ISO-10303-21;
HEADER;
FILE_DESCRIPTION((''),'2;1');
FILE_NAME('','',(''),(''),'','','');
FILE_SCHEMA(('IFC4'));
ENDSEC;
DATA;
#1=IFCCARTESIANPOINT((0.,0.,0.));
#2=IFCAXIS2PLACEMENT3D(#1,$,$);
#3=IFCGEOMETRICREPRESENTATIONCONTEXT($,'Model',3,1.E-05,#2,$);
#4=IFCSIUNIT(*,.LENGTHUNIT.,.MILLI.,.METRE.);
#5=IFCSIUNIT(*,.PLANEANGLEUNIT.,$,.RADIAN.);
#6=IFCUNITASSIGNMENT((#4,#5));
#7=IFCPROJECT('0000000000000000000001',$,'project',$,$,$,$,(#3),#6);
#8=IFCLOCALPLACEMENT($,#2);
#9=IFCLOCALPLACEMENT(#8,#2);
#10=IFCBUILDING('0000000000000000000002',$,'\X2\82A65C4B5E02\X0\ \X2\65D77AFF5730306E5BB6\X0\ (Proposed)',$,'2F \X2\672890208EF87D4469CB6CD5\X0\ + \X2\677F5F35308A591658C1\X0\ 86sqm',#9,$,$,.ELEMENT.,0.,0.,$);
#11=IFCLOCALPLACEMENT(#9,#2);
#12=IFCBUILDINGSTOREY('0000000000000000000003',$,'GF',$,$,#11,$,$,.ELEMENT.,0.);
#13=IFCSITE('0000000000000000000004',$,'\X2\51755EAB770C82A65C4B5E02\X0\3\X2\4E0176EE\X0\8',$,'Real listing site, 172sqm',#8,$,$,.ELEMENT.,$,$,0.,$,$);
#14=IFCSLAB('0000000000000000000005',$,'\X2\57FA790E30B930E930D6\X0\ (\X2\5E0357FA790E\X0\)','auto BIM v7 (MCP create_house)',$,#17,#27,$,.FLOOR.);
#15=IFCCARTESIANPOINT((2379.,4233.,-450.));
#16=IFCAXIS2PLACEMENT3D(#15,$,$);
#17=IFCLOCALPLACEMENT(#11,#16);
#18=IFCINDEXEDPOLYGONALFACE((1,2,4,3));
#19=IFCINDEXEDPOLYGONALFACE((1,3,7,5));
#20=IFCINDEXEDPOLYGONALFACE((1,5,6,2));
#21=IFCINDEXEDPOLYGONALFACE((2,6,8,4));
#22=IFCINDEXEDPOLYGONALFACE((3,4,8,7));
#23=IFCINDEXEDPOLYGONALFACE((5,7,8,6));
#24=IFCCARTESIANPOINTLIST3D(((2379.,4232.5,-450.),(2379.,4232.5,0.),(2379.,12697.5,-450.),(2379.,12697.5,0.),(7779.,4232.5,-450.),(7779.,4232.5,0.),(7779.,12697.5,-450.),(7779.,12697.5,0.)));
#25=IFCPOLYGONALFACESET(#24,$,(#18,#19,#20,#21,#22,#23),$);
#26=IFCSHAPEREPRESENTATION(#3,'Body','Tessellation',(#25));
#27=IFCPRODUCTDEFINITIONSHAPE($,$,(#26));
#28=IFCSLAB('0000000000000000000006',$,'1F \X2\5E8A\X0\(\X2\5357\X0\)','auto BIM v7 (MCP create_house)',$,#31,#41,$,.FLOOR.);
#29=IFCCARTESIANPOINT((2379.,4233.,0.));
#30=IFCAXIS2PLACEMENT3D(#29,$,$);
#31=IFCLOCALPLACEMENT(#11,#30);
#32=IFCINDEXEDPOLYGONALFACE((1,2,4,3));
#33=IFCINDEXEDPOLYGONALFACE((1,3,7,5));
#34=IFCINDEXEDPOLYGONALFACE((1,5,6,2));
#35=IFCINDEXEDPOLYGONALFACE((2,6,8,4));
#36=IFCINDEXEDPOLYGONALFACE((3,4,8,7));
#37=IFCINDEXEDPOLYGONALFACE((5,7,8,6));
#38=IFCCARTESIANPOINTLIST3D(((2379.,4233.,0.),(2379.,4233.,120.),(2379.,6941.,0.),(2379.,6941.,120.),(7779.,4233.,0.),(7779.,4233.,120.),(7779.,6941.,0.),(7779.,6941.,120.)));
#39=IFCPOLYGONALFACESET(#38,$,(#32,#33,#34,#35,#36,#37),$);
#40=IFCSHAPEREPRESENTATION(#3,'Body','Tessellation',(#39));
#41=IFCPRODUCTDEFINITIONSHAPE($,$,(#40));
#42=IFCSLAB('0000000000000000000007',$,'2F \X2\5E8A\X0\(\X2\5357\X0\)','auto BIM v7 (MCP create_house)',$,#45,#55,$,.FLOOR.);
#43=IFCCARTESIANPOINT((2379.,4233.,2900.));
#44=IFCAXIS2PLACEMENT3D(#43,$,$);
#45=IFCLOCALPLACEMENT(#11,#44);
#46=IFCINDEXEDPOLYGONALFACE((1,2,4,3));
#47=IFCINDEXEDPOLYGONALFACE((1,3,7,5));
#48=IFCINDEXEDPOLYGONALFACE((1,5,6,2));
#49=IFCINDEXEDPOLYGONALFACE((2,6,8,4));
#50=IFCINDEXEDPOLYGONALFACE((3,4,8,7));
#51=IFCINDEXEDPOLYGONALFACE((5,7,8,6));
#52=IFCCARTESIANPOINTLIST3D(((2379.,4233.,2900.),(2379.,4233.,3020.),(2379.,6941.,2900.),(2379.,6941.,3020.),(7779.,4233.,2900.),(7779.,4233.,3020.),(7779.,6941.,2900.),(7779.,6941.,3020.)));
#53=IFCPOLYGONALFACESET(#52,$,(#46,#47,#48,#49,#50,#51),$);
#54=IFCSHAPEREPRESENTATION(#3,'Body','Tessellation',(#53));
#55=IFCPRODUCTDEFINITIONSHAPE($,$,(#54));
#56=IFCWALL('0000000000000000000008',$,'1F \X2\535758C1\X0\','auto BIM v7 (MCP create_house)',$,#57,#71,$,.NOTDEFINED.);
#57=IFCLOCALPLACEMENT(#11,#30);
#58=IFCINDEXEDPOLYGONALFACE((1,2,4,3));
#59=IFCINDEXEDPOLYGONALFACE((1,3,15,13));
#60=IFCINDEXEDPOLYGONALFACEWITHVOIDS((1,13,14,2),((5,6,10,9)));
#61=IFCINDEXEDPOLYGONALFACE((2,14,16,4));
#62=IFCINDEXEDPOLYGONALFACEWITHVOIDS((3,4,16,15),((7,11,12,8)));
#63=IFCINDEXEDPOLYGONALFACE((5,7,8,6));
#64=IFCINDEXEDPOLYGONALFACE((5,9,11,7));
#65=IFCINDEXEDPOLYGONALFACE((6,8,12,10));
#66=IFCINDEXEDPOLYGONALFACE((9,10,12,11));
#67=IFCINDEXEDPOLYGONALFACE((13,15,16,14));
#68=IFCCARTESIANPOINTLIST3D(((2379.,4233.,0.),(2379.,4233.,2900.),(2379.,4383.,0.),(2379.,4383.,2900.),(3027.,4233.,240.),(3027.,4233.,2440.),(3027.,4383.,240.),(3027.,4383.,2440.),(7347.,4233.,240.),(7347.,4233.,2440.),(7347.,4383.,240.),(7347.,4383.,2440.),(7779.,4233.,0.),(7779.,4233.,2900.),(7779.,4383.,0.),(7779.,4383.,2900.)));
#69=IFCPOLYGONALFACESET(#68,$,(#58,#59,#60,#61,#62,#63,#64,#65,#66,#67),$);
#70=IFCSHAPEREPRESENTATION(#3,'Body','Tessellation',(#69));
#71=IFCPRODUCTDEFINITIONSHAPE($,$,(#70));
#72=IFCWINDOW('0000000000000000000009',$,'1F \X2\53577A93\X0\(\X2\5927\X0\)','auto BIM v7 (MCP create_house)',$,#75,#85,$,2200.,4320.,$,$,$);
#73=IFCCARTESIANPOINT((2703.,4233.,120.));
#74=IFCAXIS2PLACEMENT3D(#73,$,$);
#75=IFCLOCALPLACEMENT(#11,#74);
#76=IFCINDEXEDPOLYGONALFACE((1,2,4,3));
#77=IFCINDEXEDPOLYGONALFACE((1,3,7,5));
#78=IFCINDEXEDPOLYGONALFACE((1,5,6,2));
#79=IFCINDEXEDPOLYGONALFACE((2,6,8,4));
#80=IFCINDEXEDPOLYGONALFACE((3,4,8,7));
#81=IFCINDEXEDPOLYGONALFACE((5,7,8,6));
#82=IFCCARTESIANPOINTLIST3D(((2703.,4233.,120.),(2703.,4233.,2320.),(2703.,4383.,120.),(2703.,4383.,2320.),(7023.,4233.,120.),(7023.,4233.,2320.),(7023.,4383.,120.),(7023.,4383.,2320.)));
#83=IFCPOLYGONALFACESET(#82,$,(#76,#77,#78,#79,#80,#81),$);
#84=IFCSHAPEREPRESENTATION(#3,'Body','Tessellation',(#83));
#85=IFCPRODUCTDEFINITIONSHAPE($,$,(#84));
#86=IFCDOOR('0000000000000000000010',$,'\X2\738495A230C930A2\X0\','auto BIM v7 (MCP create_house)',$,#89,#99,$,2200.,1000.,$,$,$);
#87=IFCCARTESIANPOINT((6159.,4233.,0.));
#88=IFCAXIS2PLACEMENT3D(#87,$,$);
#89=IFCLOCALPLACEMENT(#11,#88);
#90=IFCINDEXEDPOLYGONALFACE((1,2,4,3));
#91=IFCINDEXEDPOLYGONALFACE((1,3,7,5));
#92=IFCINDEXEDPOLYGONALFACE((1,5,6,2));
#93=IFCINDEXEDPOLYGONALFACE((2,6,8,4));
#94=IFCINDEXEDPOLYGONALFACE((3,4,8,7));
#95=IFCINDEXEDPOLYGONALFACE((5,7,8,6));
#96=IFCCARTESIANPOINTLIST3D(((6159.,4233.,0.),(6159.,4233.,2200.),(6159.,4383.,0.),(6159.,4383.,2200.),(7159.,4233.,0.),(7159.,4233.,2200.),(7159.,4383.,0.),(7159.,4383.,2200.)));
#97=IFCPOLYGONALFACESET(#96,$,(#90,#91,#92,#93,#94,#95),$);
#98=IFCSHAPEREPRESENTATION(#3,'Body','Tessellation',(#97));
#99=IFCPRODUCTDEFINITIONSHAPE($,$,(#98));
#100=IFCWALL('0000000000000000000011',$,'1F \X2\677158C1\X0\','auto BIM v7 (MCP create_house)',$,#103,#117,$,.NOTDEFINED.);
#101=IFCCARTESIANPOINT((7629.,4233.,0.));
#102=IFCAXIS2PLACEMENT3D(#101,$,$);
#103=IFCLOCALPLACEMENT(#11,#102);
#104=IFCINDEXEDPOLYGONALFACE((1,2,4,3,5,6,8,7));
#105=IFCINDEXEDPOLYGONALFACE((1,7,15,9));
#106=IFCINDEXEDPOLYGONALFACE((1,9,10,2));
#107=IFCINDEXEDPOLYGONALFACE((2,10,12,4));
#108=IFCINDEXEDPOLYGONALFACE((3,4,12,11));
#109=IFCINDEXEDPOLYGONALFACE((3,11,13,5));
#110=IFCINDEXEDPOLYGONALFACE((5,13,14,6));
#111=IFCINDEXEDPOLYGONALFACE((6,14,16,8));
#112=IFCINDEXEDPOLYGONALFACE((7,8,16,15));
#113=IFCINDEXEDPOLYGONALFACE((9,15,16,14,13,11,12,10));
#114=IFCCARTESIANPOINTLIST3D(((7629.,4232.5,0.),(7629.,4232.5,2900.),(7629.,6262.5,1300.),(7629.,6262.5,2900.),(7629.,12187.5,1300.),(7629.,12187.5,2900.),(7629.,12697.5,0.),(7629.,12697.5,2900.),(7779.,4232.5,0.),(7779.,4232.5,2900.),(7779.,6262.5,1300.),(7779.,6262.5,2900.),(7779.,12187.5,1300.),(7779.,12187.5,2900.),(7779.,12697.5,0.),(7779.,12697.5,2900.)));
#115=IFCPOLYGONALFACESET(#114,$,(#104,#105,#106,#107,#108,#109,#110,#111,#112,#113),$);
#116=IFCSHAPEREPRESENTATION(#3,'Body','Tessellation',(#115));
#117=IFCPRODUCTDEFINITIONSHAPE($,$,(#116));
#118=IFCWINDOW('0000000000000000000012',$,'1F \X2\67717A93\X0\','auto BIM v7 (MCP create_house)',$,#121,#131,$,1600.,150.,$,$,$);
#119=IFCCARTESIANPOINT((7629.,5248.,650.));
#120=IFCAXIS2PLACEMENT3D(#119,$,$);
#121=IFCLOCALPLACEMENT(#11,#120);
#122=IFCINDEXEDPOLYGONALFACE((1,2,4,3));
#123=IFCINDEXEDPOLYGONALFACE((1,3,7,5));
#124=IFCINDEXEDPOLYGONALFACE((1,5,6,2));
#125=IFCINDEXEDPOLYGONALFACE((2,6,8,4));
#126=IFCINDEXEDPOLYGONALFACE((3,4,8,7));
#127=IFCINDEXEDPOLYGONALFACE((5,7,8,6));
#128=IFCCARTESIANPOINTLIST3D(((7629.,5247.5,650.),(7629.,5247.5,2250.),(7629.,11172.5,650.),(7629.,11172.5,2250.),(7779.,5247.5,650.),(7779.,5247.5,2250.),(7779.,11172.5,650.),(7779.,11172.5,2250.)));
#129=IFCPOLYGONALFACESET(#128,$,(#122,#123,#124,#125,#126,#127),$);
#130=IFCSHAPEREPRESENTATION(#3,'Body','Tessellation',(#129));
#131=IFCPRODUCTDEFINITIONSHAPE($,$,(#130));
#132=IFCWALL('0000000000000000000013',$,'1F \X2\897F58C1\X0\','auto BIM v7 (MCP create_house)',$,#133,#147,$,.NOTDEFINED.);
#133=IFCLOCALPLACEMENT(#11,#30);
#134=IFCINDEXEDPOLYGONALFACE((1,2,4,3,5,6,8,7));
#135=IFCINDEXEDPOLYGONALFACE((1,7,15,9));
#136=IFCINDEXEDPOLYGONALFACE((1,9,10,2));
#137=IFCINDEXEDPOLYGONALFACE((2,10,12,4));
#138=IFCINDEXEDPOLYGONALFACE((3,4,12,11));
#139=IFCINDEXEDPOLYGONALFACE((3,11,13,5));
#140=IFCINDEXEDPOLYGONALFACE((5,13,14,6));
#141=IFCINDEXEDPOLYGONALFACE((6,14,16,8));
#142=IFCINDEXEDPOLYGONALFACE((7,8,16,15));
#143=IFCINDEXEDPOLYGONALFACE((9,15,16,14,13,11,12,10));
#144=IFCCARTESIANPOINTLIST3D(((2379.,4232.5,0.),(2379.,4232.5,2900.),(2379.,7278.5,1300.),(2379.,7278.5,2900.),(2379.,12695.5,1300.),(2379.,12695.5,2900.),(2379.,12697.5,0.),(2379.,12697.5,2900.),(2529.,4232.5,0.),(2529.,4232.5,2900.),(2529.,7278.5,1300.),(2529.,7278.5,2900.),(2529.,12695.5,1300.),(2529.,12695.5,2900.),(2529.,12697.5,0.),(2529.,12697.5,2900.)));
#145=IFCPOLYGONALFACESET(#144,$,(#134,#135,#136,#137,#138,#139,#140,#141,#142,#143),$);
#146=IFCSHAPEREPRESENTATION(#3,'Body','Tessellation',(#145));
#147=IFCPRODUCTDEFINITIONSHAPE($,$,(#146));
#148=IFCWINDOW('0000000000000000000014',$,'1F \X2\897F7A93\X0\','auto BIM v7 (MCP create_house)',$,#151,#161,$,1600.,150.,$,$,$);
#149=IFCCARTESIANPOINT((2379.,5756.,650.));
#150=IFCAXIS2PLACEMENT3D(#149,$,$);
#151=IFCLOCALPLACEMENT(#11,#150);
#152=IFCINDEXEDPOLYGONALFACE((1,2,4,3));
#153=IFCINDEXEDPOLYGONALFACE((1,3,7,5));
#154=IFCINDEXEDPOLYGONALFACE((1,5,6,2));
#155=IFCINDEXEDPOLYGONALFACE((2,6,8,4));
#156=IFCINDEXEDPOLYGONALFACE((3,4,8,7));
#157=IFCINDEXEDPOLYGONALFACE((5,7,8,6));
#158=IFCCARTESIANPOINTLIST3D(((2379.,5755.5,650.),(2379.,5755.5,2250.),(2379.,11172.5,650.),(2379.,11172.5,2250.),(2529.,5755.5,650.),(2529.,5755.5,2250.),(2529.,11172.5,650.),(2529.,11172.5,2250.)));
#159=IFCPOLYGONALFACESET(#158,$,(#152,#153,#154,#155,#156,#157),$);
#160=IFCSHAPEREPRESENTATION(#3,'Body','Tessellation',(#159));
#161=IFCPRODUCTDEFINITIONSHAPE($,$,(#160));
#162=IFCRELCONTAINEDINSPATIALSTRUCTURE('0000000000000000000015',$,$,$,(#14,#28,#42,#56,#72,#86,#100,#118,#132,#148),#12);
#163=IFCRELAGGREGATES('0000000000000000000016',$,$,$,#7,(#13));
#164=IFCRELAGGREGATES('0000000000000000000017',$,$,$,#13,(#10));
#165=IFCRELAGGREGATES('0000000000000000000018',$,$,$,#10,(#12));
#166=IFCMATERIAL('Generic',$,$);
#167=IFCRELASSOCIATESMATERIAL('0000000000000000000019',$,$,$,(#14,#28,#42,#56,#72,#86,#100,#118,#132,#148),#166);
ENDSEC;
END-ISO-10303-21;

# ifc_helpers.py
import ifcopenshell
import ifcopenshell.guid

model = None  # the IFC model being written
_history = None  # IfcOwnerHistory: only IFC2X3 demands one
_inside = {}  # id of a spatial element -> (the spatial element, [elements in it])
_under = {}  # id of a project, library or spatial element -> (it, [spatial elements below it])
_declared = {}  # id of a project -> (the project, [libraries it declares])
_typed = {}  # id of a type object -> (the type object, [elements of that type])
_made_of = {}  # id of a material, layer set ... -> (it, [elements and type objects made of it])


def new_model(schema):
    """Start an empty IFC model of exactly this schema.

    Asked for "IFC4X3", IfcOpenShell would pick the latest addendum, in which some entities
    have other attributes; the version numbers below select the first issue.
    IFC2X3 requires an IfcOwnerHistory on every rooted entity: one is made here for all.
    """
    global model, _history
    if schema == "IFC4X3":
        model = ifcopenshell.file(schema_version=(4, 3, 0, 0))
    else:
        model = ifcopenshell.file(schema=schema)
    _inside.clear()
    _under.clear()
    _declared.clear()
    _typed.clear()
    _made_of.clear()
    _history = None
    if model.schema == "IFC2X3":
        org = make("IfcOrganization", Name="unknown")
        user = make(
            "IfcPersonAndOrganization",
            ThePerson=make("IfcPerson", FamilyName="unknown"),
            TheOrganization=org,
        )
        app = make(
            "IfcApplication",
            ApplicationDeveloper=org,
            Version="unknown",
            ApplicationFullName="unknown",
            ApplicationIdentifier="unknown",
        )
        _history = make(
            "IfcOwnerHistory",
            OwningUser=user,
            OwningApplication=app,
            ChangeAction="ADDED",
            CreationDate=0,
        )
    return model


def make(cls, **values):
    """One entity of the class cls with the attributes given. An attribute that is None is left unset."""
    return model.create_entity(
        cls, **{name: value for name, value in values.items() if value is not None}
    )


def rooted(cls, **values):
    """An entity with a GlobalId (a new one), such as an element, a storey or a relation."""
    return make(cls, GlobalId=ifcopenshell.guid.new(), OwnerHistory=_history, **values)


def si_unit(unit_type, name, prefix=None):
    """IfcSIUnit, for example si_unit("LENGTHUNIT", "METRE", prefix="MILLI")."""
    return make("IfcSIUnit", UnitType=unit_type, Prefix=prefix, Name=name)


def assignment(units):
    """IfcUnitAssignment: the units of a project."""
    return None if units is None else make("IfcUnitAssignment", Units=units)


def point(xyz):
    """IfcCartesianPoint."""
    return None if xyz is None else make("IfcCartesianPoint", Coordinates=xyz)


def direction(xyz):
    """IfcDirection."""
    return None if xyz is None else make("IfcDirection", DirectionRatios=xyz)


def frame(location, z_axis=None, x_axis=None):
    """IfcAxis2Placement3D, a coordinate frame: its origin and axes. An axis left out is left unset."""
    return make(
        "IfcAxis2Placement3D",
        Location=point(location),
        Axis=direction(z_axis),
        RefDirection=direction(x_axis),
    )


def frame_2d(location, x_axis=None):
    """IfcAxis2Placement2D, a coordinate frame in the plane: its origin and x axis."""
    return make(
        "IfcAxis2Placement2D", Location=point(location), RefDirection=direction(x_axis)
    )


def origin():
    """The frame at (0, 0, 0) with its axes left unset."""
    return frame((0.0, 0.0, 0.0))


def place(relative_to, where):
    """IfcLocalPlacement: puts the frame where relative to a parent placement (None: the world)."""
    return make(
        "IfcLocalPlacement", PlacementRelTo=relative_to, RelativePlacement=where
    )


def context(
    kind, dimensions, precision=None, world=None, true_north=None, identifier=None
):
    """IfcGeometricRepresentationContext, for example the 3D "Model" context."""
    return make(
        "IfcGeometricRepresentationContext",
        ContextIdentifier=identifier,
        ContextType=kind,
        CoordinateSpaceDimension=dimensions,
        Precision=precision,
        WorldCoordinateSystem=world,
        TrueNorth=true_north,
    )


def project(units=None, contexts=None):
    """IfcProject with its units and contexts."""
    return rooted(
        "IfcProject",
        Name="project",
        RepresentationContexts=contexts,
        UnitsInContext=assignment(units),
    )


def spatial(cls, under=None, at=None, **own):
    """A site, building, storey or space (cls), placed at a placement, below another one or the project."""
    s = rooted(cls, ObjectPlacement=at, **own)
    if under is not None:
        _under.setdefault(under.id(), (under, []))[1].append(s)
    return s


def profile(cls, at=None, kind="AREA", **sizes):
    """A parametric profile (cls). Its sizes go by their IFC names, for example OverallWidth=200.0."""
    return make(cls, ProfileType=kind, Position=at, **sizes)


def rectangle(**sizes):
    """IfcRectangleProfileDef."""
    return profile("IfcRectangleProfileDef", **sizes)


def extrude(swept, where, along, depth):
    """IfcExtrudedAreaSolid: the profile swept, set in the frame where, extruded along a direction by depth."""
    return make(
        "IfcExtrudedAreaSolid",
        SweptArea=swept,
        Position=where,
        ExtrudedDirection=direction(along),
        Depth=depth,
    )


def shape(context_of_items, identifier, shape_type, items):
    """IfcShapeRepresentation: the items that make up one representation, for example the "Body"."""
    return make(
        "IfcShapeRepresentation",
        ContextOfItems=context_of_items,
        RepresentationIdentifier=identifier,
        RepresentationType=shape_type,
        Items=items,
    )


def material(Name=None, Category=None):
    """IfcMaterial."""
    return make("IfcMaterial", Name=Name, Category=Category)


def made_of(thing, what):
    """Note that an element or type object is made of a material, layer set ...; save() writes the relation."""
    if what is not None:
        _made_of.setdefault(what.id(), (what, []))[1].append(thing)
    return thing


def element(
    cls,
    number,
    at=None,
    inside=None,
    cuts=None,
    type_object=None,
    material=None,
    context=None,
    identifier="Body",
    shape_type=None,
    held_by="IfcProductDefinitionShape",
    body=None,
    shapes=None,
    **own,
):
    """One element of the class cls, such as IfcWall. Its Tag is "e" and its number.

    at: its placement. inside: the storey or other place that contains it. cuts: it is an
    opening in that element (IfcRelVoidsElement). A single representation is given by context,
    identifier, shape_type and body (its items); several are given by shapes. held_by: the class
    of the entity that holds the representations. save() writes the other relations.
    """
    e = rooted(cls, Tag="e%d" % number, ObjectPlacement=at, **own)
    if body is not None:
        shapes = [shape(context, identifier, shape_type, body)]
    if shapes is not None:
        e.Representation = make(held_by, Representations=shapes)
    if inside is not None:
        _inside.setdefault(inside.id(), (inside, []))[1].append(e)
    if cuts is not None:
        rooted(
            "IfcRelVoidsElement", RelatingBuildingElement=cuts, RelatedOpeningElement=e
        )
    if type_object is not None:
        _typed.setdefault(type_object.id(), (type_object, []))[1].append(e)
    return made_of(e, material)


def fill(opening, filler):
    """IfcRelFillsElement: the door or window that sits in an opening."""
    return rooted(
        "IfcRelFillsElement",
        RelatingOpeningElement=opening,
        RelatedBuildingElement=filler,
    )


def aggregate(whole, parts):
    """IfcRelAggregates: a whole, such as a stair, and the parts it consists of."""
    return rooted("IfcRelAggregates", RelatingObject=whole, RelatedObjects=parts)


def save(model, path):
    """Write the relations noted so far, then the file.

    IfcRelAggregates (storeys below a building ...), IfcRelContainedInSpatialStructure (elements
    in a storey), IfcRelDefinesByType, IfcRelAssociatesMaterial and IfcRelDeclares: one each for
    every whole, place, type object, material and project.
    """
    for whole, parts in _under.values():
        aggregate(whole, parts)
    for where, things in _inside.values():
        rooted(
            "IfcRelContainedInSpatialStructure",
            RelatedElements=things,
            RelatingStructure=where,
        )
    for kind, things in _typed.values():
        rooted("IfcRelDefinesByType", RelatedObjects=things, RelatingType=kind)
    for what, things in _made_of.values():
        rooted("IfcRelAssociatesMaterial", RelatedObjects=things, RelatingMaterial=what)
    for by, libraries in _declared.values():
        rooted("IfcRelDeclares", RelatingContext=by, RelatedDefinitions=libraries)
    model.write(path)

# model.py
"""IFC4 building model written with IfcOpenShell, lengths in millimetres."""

from ifc_helpers import new_model, si_unit, frame, frame_2d, origin, place, context, project, spatial, rectangle, extrude, material, element, fill, save


model = new_model("IFC4")

# Units and contexts
model_context = context("Model", 3, precision=1e-05, world=origin())
ifc_project = project(units=[si_unit("LENGTHUNIT", "METRE", prefix="MILLI"), si_unit("PLANEANGLEUNIT", "RADIAN")], contexts=[model_context])

# Site, building, storey
site_placement = place(None, origin())
site = spatial("IfcSite", under=ifc_project, at=site_placement, Name="兵庫県芦屋市3丁目8", ObjectType="Real listing site, 172sqm", CompositionType="ELEMENT", RefElevation=0.0)
building_placement = place(site_placement, origin())
building = spatial("IfcBuilding", under=site, at=building_placement, Name="芦屋市 旗竿地の家 (Proposed)", ObjectType="2F 木造軸組構法 + 板張り外壁 86sqm", CompositionType="ELEMENT", ElevationOfRefHeight=0.0, ElevationOfTerrain=0.0)
storey_placement = place(building_placement, origin())
storey = spatial("IfcBuildingStorey", under=building, at=storey_placement, Name="GF", CompositionType="ELEMENT", Elevation=0.0)

# Slabs
ifc_material = material(Name="Generic")
slab_1_placement = place(storey_placement, frame((2379.0, 4233.0, -450.0)))
element("IfcSlab", 1, at=slab_1_placement, inside=storey, material=ifc_material, Name="基礎スラブ (布基礎)", Description="auto BIM v7 (MCP create_house)", PredefinedType="FLOOR", context=model_context, shape_type="SweptSolid", body=[
    extrude(rectangle(XDim=5400.0, YDim=8465.0, at=frame_2d((2700.0, 4232.0))), frame((2379.0, 4233.0, -450.0)), (0.0, 0.0, 1.0), 450.0),
])
slab_2_placement = place(storey_placement, frame((2379.0, 4233.0, 0.0)))
element("IfcSlab", 2, at=slab_2_placement, inside=storey, material=ifc_material, Name="1F 床(南)", Description="auto BIM v7 (MCP create_house)", PredefinedType="FLOOR", context=model_context, shape_type="SweptSolid", body=[
    extrude(rectangle(XDim=5400.0, YDim=2708.0, at=frame_2d((2700.0, 1354.0))), frame((2379.0, 4233.0, 0.0)), (0.0, 0.0, 1.0), 120.0),
])
slab_3_placement = place(storey_placement, frame((2379.0, 4233.0, 2900.0)))
element("IfcSlab", 3, at=slab_3_placement, inside=storey, material=ifc_material, Name="2F 床(南)", Description="auto BIM v7 (MCP create_house)", PredefinedType="FLOOR", context=model_context, shape_type="SweptSolid", body=[
    extrude(rectangle(XDim=5400.0, YDim=2708.0, at=frame_2d((2700.0, 1354.0))), frame((2379.0, 4233.0, 2900.0)), (0.0, 0.0, 1.0), 120.0),
])

# Wall, openings, window, door
wall_1_placement = place(storey_placement, frame((2379.0, 4233.0, 0.0)))
wall_1 = element("IfcWall", 4, at=wall_1_placement, inside=storey, material=ifc_material, Name="1F 南壁", Description="auto BIM v7 (MCP create_house)", PredefinedType="NOTDEFINED", context=model_context, shape_type="SweptSolid", body=[
    extrude(rectangle(XDim=5400.0, YDim=150.0, at=frame_2d((2700.0, 75.0))), frame((2379.0, 4233.0, 0.0)), (0.0, 0.0, 1.0), 2900.0),
])
opening_1_placement = place(storey_placement, frame((2703.0, 4233.0, 120.0)))
opening_1 = element("IfcOpeningElement", 5, at=opening_1_placement, cuts=wall_1, PredefinedType="NOTDEFINED", context=model_context, shape_type="SweptSolid", body=[
    extrude(rectangle(XDim=4320.0, YDim=150.0, at=frame_2d((2160.0, 75.0))), frame((2703.0, 4233.0, 120.0)), (0.0, 0.0, 1.0), 2200.0),
])
opening_2_placement = place(storey_placement, frame((6159.0, 4233.0, 0.0)))
opening_2 = element("IfcOpeningElement", 6, at=opening_2_placement, cuts=wall_1, PredefinedType="NOTDEFINED", context=model_context, shape_type="SweptSolid", body=[
    extrude(rectangle(XDim=1000.0, YDim=150.0, at=frame_2d((500.0, 75.0))), frame((6159.0, 4233.0, 0.0)), (0.0, 0.0, 1.0), 2200.0),
])
window_1_placement = place(storey_placement, frame((2703.0, 4233.0, 120.0)))
window_1 = element("IfcWindow", 7, at=window_1_placement, inside=storey, material=ifc_material, Name="1F 南窓(大)", Description="auto BIM v7 (MCP create_house)", OverallHeight=2200.0, OverallWidth=4320.0, context=model_context, shape_type="SweptSolid", body=[
    extrude(rectangle(XDim=4320.0, YDim=150.0, at=frame_2d((2160.0, 75.0))), frame((2703.0, 4233.0, 120.0)), (0.0, 0.0, 1.0), 2200.0),
])
fill(opening_1, window_1)
door_placement = place(storey_placement, frame((6159.0, 4233.0, 0.0)))
door = element("IfcDoor", 8, at=door_placement, inside=storey, material=ifc_material, Name="玄関ドア", Description="auto BIM v7 (MCP create_house)", OverallHeight=2200.0, OverallWidth=1000.0, context=model_context, shape_type="SweptSolid", body=[
    extrude(rectangle(XDim=1000.0, YDim=150.0, at=frame_2d((500.0, 75.0))), frame((6159.0, 4233.0, 0.0)), (0.0, 0.0, 1.0), 2200.0),
])
fill(opening_2, door)

# Walls, openings, windows
wall_2_placement = place(storey_placement, frame((7629.0, 4233.0, 0.0)))
wall_2 = element("IfcWall", 9, at=wall_2_placement, inside=storey, material=ifc_material, Name="1F 東壁", Description="auto BIM v7 (MCP create_house)", PredefinedType="NOTDEFINED", context=model_context, shape_type="SweptSolid", body=[
    extrude(rectangle(XDim=150.0, YDim=8465.0, at=frame_2d((75.0, 4232.0))), frame((7629.0, 4233.0, 0.0)), (0.0, 0.0, 1.0), 2900.0),
])
opening_3_placement = place(storey_placement, frame((7629.0, 5248.0, 650.0)))
opening_3 = element("IfcOpeningElement", 10, at=opening_3_placement, cuts=wall_2, PredefinedType="NOTDEFINED", context=model_context, shape_type="SweptSolid", body=[
    extrude(rectangle(XDim=150.0, YDim=5925.0, at=frame_2d((75.0, 2962.0))), frame((7629.0, 5248.0, 650.0)), (0.0, 0.0, 1.0), 1600.0),
])
window_2_placement = place(storey_placement, frame((7629.0, 5248.0, 650.0)))
window_2 = element("IfcWindow", 11, at=window_2_placement, inside=storey, material=ifc_material, Name="1F 東窓", Description="auto BIM v7 (MCP create_house)", OverallHeight=1600.0, OverallWidth=150.0, context=model_context, shape_type="SweptSolid", body=[
    extrude(rectangle(XDim=150.0, YDim=5925.0, at=frame_2d((75.0, 2962.0))), frame((7629.0, 5248.0, 650.0)), (0.0, 0.0, 1.0), 1600.0),
])
fill(opening_3, window_2)
wall_3_placement = place(storey_placement, frame((2379.0, 4233.0, 0.0)))
wall_3 = element("IfcWall", 12, at=wall_3_placement, inside=storey, material=ifc_material, Name="1F 西壁", Description="auto BIM v7 (MCP create_house)", PredefinedType="NOTDEFINED", context=model_context, shape_type="SweptSolid", body=[
    extrude(rectangle(XDim=150.0, YDim=8465.0, at=frame_2d((75.0, 4232.0))), frame((2379.0, 4233.0, 0.0)), (0.0, 0.0, 1.0), 2900.0),
])
opening_4_placement = place(storey_placement, frame((2379.0, 5756.0, 650.0)))
opening_4 = element("IfcOpeningElement", 13, at=opening_4_placement, cuts=wall_3, PredefinedType="NOTDEFINED", context=model_context, shape_type="SweptSolid", body=[
    extrude(rectangle(XDim=150.0, YDim=5417.0, at=frame_2d((75.0, 2708.0))), frame((2379.0, 5756.0, 650.0)), (0.0, 0.0, 1.0), 1600.0),
])
window_3_placement = place(storey_placement, frame((2379.0, 5756.0, 650.0)))
window_3 = element("IfcWindow", 14, at=window_3_placement, inside=storey, material=ifc_material, Name="1F 西窓", Description="auto BIM v7 (MCP create_house)", OverallHeight=1600.0, OverallWidth=150.0, context=model_context, shape_type="SweptSolid", body=[
    extrude(rectangle(XDim=150.0, YDim=5417.0, at=frame_2d((75.0, 2708.0))), frame((2379.0, 5756.0, 650.0)), (0.0, 0.0, 1.0), 1600.0),
])
fill(opening_4, window_3)

save(model, "model.ifc")
